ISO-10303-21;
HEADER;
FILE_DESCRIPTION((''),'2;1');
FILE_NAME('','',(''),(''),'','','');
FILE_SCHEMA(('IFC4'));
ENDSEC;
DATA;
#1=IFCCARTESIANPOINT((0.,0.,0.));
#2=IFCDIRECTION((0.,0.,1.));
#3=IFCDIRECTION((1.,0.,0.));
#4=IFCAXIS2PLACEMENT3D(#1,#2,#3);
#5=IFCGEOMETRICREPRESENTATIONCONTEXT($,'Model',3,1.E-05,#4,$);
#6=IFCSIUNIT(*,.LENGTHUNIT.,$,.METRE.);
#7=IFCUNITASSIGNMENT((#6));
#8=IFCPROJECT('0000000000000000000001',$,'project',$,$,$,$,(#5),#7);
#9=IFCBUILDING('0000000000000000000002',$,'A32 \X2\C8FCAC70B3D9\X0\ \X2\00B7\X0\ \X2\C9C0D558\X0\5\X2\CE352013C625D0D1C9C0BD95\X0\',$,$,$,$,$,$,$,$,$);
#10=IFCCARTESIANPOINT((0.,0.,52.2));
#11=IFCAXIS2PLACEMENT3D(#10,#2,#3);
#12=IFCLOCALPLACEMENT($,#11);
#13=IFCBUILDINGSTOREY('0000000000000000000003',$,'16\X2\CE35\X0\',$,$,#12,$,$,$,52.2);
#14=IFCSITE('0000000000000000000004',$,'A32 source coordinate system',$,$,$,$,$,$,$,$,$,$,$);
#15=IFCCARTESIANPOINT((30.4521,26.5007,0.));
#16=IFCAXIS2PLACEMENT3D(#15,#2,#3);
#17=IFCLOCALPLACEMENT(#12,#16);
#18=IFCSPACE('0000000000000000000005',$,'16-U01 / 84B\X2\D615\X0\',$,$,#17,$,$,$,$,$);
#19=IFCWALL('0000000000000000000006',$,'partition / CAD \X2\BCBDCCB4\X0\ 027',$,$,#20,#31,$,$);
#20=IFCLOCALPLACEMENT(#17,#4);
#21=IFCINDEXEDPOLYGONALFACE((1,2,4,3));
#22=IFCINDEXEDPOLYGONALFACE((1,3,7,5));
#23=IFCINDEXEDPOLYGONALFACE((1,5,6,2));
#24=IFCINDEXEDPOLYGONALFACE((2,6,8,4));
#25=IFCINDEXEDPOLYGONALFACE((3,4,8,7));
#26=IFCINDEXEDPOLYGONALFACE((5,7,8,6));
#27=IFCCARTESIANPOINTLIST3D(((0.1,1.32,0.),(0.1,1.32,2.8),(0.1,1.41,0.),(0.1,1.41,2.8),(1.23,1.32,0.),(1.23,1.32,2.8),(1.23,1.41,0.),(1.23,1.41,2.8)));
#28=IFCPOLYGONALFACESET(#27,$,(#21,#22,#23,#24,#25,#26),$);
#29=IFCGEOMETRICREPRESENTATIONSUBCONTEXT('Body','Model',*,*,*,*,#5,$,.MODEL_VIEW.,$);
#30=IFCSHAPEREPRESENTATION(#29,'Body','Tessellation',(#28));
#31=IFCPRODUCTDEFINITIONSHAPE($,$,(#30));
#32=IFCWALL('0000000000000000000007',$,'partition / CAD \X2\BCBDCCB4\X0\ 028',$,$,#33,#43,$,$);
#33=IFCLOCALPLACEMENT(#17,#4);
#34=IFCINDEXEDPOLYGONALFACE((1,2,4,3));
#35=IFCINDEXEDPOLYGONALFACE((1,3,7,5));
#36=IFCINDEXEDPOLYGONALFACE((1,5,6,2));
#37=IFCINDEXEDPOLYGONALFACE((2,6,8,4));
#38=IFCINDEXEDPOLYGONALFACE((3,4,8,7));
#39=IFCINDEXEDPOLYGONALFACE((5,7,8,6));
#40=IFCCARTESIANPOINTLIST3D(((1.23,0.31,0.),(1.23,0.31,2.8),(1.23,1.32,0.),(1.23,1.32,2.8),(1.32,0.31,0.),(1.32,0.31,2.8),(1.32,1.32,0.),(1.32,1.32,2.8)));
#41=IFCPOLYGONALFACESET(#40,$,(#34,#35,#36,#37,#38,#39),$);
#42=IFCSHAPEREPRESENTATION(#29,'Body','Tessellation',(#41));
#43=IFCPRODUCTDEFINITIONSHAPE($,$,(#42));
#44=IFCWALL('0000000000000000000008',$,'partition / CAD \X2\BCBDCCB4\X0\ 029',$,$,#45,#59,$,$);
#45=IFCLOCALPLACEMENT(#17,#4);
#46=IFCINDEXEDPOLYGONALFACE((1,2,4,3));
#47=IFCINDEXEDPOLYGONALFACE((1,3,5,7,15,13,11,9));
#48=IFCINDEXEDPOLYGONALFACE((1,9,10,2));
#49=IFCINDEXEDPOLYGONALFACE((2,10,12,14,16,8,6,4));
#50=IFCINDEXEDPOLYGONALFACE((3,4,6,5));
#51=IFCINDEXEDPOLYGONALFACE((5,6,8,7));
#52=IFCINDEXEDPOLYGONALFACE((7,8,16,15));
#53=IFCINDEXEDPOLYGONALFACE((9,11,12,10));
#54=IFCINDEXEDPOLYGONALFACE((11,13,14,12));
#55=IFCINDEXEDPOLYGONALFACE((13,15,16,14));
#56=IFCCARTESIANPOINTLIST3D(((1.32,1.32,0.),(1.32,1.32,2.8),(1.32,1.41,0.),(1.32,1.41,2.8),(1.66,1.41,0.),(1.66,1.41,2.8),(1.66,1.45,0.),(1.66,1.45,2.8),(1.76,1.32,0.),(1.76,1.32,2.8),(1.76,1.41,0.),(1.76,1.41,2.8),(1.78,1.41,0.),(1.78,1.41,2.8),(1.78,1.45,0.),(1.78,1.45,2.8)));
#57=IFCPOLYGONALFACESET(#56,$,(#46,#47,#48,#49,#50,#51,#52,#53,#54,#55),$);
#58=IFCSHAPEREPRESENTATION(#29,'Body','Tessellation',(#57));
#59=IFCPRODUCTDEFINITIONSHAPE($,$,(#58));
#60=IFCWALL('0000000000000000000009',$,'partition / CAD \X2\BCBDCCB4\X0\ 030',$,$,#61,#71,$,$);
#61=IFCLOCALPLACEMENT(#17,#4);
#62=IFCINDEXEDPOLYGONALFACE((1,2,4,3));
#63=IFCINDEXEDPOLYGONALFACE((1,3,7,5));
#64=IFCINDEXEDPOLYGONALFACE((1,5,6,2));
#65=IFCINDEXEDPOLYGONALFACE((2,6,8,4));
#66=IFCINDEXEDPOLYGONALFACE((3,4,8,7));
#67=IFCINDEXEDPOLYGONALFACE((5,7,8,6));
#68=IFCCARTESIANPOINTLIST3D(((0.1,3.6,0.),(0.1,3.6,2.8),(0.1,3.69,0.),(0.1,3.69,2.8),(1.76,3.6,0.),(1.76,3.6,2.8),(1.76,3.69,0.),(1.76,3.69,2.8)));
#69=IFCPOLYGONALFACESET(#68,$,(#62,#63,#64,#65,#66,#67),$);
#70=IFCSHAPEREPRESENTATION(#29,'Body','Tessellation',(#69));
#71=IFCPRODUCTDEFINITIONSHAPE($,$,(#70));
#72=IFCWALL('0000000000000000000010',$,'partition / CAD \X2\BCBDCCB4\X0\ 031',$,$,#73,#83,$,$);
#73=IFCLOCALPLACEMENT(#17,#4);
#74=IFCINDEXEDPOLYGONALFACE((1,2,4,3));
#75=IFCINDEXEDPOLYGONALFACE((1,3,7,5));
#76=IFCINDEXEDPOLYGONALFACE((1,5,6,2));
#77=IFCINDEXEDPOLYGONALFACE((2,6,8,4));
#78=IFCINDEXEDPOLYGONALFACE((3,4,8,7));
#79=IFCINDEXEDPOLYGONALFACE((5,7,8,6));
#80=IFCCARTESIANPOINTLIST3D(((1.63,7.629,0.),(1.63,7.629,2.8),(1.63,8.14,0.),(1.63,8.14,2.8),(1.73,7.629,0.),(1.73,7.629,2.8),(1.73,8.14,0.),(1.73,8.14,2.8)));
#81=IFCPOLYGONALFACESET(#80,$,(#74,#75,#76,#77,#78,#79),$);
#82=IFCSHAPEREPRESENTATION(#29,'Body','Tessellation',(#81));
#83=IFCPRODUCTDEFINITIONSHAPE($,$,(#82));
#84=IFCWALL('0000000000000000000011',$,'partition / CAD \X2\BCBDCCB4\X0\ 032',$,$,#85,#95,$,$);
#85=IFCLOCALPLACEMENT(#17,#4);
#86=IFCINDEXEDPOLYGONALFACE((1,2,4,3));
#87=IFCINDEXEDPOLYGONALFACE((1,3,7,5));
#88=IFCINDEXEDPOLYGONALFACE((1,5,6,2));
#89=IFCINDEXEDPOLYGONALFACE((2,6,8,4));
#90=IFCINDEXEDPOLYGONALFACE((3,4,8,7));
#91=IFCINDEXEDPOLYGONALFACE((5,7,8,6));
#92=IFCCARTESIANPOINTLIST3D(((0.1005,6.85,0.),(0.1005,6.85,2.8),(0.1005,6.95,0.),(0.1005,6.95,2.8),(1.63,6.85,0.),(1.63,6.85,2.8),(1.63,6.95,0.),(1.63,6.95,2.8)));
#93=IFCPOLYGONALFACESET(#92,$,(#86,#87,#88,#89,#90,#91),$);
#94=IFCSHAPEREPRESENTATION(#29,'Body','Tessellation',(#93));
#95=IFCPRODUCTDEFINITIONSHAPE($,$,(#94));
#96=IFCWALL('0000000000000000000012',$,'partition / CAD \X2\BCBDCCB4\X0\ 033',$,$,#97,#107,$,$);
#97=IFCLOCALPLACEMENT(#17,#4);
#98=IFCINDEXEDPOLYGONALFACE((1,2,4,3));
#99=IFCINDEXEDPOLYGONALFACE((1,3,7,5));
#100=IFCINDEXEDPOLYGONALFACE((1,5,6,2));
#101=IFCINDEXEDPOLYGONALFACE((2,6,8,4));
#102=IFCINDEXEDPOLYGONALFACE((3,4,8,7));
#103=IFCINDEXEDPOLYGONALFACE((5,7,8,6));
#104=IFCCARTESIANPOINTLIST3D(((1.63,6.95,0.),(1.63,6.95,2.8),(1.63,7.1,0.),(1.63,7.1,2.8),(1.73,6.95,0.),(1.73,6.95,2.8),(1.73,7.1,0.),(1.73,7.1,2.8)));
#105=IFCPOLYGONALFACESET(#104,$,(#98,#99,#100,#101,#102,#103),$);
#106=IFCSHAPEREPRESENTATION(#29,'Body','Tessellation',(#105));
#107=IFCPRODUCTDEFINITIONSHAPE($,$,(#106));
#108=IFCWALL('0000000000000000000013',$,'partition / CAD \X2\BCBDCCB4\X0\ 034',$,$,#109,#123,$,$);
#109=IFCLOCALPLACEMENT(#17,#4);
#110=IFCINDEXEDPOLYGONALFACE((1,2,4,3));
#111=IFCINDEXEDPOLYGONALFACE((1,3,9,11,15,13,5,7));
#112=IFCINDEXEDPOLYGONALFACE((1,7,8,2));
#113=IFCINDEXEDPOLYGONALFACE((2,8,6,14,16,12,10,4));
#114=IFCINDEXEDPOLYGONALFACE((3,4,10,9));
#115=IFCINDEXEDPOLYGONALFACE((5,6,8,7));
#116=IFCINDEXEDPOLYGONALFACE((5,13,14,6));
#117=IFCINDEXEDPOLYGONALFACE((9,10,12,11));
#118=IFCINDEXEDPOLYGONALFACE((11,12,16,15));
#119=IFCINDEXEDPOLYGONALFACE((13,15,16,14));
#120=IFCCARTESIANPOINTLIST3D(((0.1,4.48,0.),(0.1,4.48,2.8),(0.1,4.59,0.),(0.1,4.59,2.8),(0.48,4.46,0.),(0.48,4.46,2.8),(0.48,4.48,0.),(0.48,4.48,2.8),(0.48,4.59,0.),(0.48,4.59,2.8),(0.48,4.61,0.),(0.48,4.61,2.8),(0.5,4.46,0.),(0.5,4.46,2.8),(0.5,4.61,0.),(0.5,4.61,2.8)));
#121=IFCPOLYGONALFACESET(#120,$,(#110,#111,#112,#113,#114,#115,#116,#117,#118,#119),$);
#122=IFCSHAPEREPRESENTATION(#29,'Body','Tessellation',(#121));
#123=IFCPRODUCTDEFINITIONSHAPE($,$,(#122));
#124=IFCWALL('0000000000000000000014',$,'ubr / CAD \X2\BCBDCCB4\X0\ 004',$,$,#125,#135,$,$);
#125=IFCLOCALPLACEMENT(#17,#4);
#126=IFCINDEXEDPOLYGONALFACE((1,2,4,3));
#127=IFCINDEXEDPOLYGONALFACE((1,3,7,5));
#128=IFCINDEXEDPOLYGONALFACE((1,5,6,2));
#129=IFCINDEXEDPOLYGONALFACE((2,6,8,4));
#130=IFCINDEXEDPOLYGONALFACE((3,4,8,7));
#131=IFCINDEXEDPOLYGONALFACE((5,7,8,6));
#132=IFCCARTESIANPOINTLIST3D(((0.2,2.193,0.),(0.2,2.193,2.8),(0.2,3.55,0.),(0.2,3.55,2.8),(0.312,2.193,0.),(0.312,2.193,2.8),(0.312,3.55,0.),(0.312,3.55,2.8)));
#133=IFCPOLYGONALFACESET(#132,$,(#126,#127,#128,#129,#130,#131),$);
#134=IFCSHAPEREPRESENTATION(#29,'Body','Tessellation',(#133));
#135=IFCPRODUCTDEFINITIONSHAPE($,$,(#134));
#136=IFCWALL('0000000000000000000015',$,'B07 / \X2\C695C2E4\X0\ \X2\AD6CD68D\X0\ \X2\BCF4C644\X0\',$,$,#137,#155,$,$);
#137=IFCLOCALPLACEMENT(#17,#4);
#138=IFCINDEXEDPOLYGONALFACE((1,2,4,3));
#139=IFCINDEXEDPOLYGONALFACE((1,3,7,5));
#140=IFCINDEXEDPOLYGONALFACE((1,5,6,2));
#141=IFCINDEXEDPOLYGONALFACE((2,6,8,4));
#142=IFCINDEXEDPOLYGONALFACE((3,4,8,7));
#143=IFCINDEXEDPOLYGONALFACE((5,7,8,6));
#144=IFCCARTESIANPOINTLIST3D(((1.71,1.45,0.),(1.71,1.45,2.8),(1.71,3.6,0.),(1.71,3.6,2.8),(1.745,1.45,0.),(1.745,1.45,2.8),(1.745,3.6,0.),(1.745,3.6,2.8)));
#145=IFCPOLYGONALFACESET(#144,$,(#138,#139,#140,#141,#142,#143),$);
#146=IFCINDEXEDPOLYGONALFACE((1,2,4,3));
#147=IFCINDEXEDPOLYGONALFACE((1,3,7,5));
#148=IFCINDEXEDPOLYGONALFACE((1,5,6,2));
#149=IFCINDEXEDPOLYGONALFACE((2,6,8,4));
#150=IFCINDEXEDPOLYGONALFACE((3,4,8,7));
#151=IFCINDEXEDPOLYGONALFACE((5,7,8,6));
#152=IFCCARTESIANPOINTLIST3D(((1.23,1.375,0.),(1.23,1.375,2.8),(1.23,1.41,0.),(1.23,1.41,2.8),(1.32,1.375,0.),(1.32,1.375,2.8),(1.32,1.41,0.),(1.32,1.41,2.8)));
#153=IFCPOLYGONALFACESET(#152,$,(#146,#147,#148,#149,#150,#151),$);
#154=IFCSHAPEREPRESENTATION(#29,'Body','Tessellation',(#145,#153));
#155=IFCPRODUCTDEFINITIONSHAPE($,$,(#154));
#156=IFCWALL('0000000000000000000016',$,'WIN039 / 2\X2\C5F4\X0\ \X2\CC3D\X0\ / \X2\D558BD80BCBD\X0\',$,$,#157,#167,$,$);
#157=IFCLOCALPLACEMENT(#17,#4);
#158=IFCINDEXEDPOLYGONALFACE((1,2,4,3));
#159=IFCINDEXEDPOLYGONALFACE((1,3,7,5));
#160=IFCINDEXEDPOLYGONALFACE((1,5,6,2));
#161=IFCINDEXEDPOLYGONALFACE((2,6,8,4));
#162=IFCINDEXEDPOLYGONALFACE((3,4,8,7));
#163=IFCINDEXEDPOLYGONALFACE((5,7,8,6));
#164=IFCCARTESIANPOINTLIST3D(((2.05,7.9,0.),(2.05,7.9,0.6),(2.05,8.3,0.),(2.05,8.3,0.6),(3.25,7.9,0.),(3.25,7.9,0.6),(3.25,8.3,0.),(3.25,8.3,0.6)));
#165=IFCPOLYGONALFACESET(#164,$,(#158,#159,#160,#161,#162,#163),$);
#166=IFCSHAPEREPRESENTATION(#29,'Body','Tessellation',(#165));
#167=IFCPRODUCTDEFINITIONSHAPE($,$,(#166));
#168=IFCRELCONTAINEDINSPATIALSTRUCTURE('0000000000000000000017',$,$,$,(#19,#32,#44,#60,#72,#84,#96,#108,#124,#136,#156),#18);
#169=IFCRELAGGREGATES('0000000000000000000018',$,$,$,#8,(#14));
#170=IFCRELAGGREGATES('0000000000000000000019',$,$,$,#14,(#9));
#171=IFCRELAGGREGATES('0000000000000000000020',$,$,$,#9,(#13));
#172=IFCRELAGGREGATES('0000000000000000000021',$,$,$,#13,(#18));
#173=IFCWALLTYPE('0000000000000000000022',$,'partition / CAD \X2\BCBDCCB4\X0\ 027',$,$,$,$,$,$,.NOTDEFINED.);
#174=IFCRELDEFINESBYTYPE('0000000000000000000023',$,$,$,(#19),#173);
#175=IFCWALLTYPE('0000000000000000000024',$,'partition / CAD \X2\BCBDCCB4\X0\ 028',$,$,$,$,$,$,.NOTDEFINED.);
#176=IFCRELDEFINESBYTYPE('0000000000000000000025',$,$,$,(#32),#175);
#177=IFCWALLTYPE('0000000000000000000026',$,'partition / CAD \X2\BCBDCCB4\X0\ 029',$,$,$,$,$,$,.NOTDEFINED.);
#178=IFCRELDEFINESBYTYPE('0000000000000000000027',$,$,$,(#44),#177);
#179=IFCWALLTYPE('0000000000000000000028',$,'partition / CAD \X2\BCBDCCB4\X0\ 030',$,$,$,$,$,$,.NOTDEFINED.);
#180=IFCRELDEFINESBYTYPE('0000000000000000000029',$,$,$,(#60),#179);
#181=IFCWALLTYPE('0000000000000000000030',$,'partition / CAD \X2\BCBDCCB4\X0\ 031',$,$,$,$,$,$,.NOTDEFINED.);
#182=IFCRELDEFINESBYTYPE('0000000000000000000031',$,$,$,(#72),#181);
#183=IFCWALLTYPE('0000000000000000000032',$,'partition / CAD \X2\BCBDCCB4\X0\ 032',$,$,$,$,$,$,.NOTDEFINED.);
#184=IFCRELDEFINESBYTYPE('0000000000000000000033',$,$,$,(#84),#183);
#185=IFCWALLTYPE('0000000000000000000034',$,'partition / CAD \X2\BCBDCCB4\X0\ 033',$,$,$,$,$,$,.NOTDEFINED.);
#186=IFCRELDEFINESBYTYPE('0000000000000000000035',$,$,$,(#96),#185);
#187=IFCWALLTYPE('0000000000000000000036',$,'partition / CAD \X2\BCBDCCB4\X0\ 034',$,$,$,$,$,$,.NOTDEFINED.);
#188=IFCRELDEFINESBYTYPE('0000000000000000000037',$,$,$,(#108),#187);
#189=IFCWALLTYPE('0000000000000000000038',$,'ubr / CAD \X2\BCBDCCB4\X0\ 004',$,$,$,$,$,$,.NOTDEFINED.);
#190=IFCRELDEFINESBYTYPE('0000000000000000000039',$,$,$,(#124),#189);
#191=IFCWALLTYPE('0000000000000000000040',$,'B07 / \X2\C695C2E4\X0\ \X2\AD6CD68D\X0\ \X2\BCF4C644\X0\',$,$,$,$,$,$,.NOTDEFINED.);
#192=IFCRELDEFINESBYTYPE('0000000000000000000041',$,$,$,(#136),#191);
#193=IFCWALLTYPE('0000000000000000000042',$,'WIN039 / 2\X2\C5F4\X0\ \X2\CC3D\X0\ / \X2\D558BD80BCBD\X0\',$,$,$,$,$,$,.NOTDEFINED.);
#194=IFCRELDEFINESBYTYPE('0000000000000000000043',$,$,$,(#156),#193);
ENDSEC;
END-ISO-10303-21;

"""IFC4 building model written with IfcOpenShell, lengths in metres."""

from ifc_helpers import new_model, si_unit, frame, origin, origin_with_axes, place, context, subcontext, project, spatial, polyline, outline, extrude, source, transform, mapped, type_object, type_shapes, element, save


model = new_model("IFC4")

# Units and contexts
model_context = context("Model", 3, precision=1e-05, world=origin_with_axes())
body_context = subcontext(model_context, "Body", "Model", "MODEL_VIEW")
ifc_project = project(units=[si_unit("LENGTHUNIT", "METRE")], contexts=[model_context])

# Site, building, storey, space
site = spatial("IfcSite", under=ifc_project, Name="A32 source coordinate system")
building = spatial("IfcBuilding", under=site, Name="A32 주거동 · 지하5층–옥탑지붕")
storey_placement = place(None, frame((0.0, 0.0, 52.2), z_axis=(0.0, 0.0, 1.0), x_axis=(1.0, 0.0, 0.0)))
storey = spatial("IfcBuildingStorey", under=building, at=storey_placement, Name="16층", Elevation=52.2)
space_placement = place(storey_placement, frame((30.4521, 26.5007, 0.0), z_axis=(0.0, 0.0, 1.0), x_axis=(1.0, 0.0, 0.0)))
space = spatial("IfcSpace", under=storey, at=space_placement, Name="16-U01 / 84B형")

# Walls
wall_type_1 = type_object("IfcWallType", Name="partition / CAD 벽체 027", PredefinedType="NOTDEFINED")
shared_shape_1 = source(origin(), body_context, "Body", "SweptSolid", [
    extrude(outline(polyline([(0.1, 1.32), (0.1, 1.41), (1.23, 1.41), (1.23, 1.32), (0.1, 1.32)])), origin(), (0.0, 0.0, 1.0), 2.8),
])
type_shapes(wall_type_1, [shared_shape_1])
wall_1_placement = place(space_placement, origin_with_axes())
element("IfcWall", 1, at=wall_1_placement, inside=space, type_object=wall_type_1, Name="partition / CAD 벽체 027", context=body_context, shape_type="MappedRepresentation", body=[
    mapped(shared_shape_1, transform((0.0, 0.0, 0.0), scale=1.0)),
])
wall_type_2 = type_object("IfcWallType", Name="partition / CAD 벽체 028", PredefinedType="NOTDEFINED")
shared_shape_2 = source(origin(), body_context, "Body", "SweptSolid", [
    extrude(outline(polyline([(1.32, 0.31), (1.23, 0.31), (1.23, 1.32), (1.32, 1.32), (1.32, 0.31)])), origin(), (0.0, 0.0, 1.0), 2.8),
])
type_shapes(wall_type_2, [shared_shape_2])
wall_2_placement = place(space_placement, origin_with_axes())
element("IfcWall", 2, at=wall_2_placement, inside=space, type_object=wall_type_2, Name="partition / CAD 벽체 028", context=body_context, shape_type="MappedRepresentation", body=[
    mapped(shared_shape_2, transform((0.0, 0.0, 0.0), scale=1.0)),
])
wall_type_3 = type_object("IfcWallType", Name="partition / CAD 벽체 029", PredefinedType="NOTDEFINED")
shared_shape_3 = source(origin(), body_context, "Body", "SweptSolid", [
    extrude(outline(polyline([(1.66, 1.41), (1.66, 1.45), (1.78, 1.45), (1.78, 1.41), (1.76, 1.41), (1.76, 1.32), (1.32, 1.32), (1.32, 1.41), (1.66, 1.41)])), origin(), (0.0, 0.0, 1.0), 2.8),
])
type_shapes(wall_type_3, [shared_shape_3])
wall_3_placement = place(space_placement, origin_with_axes())
element("IfcWall", 3, at=wall_3_placement, inside=space, type_object=wall_type_3, Name="partition / CAD 벽체 029", context=body_context, shape_type="MappedRepresentation", body=[
    mapped(shared_shape_3, transform((0.0, 0.0, 0.0), scale=1.0)),
])
wall_type_4 = type_object("IfcWallType", Name="partition / CAD 벽체 030", PredefinedType="NOTDEFINED")
shared_shape_4 = source(origin(), body_context, "Body", "SweptSolid", [
    extrude(outline(polyline([(1.76, 3.69), (1.76, 3.6), (0.1, 3.6), (0.1, 3.69), (1.76, 3.69)])), origin(), (0.0, 0.0, 1.0), 2.8),
])
type_shapes(wall_type_4, [shared_shape_4])
wall_4_placement = place(space_placement, origin_with_axes())
element("IfcWall", 4, at=wall_4_placement, inside=space, type_object=wall_type_4, Name="partition / CAD 벽체 030", context=body_context, shape_type="MappedRepresentation", body=[
    mapped(shared_shape_4, transform((0.0, 0.0, 0.0), scale=1.0)),
])
wall_type_5 = type_object("IfcWallType", Name="partition / CAD 벽체 031", PredefinedType="NOTDEFINED")
shared_shape_5 = source(origin(), body_context, "Body", "SweptSolid", [
    extrude(outline(polyline([(1.63, 8.14), (1.73, 8.14), (1.73, 7.629), (1.63, 7.629), (1.63, 8.14)])), origin(), (0.0, 0.0, 1.0), 2.8),
])
type_shapes(wall_type_5, [shared_shape_5])
wall_5_placement = place(space_placement, origin_with_axes())
element("IfcWall", 5, at=wall_5_placement, inside=space, type_object=wall_type_5, Name="partition / CAD 벽체 031", context=body_context, shape_type="MappedRepresentation", body=[
    mapped(shared_shape_5, transform((0.0, 0.0, 0.0), scale=1.0)),
])
wall_type_6 = type_object("IfcWallType", Name="partition / CAD 벽체 032", PredefinedType="NOTDEFINED")
shared_shape_6 = source(origin(), body_context, "Body", "SweptSolid", [
    extrude(outline(polyline([(0.1005, 6.95), (1.63, 6.95), (1.63, 6.85), (0.1005, 6.85), (0.1005, 6.95)])), origin(), (0.0, 0.0, 1.0), 2.8),
])
type_shapes(wall_type_6, [shared_shape_6])
wall_6_placement = place(space_placement, origin_with_axes())
element("IfcWall", 6, at=wall_6_placement, inside=space, type_object=wall_type_6, Name="partition / CAD 벽체 032", context=body_context, shape_type="MappedRepresentation", body=[
    mapped(shared_shape_6, transform((0.0, 0.0, 0.0), scale=1.0)),
])
wall_type_7 = type_object("IfcWallType", Name="partition / CAD 벽체 033", PredefinedType="NOTDEFINED")
shared_shape_7 = source(origin(), body_context, "Body", "SweptSolid", [
    extrude(outline(polyline([(1.63, 7.1), (1.73, 7.1), (1.73, 6.95), (1.63, 6.95), (1.63, 7.1)])), origin(), (0.0, 0.0, 1.0), 2.8),
])
type_shapes(wall_type_7, [shared_shape_7])
wall_7_placement = place(space_placement, origin_with_axes())
element("IfcWall", 7, at=wall_7_placement, inside=space, type_object=wall_type_7, Name="partition / CAD 벽체 033", context=body_context, shape_type="MappedRepresentation", body=[
    mapped(shared_shape_7, transform((0.0, 0.0, 0.0), scale=1.0)),
])
wall_type_8 = type_object("IfcWallType", Name="partition / CAD 벽체 034", PredefinedType="NOTDEFINED")
shared_shape_8 = source(origin(), body_context, "Body", "SweptSolid", [
    extrude(outline(polyline([(0.48, 4.61), (0.5, 4.61), (0.5, 4.46), (0.48, 4.46), (0.48, 4.48), (0.1, 4.48), (0.1, 4.59), (0.48, 4.59), (0.48, 4.61)])), origin(), (0.0, 0.0, 1.0), 2.8),
])
type_shapes(wall_type_8, [shared_shape_8])
wall_8_placement = place(space_placement, origin_with_axes())
element("IfcWall", 8, at=wall_8_placement, inside=space, type_object=wall_type_8, Name="partition / CAD 벽체 034", context=body_context, shape_type="MappedRepresentation", body=[
    mapped(shared_shape_8, transform((0.0, 0.0, 0.0), scale=1.0)),
])
wall_type_9 = type_object("IfcWallType", Name="ubr / CAD 벽체 004", PredefinedType="NOTDEFINED")
shared_shape_9 = source(origin(), body_context, "Body", "SweptSolid", [
    extrude(outline(polyline([(0.312, 2.193), (0.2, 2.193), (0.2, 3.55), (0.312, 3.55), (0.312, 2.193)])), origin(), (0.0, 0.0, 1.0), 2.8),
])
type_shapes(wall_type_9, [shared_shape_9])
wall_9_placement = place(space_placement, origin_with_axes())
element("IfcWall", 9, at=wall_9_placement, inside=space, type_object=wall_type_9, Name="ubr / CAD 벽체 004", context=body_context, shape_type="MappedRepresentation", body=[
    mapped(shared_shape_9, transform((0.0, 0.0, 0.0), scale=1.0)),
])
wall_type_10 = type_object("IfcWallType", Name="B07 / 욕실 구획 보완", PredefinedType="NOTDEFINED")
shared_shape_10 = source(origin(), body_context, "Body", "SweptSolid", [
    extrude(outline(polyline([(1.71, 1.45), (1.71, 3.6), (1.745, 3.6), (1.745, 1.45), (1.71, 1.45)])), origin(), (0.0, 0.0, 1.0), 2.8),
    extrude(outline(polyline([(1.32, 1.41), (1.32, 1.375), (1.23, 1.375), (1.23, 1.41), (1.32, 1.41)])), origin(), (0.0, 0.0, 1.0), 2.8),
])
type_shapes(wall_type_10, [shared_shape_10])
wall_10_placement = place(space_placement, origin_with_axes())
element("IfcWall", 10, at=wall_10_placement, inside=space, type_object=wall_type_10, Name="B07 / 욕실 구획 보완", context=body_context, shape_type="MappedRepresentation", body=[
    mapped(shared_shape_10, transform((0.0, 0.0, 0.0), scale=1.0)),
])
wall_type_11 = type_object("IfcWallType", Name="WIN039 / 2열 창 / 하부벽", PredefinedType="NOTDEFINED")
shared_shape_11 = source(origin(), body_context, "Body", "SweptSolid", [
    extrude(outline(polyline([(2.05, 8.3), (3.25, 8.3), (3.25, 7.9), (2.05, 7.9), (2.05, 8.3)])), origin(), (0.0, 0.0, 1.0), 0.6),
])
type_shapes(wall_type_11, [shared_shape_11])
wall_11_placement = place(space_placement, origin_with_axes())
element("IfcWall", 11, at=wall_11_placement, inside=space, type_object=wall_type_11, Name="WIN039 / 2열 창 / 하부벽", context=body_context, shape_type="MappedRepresentation", body=[
    mapped(shared_shape_11, transform((0.0, 0.0, 0.0), scale=1.0)),
])

save(model, "model.ifc")
